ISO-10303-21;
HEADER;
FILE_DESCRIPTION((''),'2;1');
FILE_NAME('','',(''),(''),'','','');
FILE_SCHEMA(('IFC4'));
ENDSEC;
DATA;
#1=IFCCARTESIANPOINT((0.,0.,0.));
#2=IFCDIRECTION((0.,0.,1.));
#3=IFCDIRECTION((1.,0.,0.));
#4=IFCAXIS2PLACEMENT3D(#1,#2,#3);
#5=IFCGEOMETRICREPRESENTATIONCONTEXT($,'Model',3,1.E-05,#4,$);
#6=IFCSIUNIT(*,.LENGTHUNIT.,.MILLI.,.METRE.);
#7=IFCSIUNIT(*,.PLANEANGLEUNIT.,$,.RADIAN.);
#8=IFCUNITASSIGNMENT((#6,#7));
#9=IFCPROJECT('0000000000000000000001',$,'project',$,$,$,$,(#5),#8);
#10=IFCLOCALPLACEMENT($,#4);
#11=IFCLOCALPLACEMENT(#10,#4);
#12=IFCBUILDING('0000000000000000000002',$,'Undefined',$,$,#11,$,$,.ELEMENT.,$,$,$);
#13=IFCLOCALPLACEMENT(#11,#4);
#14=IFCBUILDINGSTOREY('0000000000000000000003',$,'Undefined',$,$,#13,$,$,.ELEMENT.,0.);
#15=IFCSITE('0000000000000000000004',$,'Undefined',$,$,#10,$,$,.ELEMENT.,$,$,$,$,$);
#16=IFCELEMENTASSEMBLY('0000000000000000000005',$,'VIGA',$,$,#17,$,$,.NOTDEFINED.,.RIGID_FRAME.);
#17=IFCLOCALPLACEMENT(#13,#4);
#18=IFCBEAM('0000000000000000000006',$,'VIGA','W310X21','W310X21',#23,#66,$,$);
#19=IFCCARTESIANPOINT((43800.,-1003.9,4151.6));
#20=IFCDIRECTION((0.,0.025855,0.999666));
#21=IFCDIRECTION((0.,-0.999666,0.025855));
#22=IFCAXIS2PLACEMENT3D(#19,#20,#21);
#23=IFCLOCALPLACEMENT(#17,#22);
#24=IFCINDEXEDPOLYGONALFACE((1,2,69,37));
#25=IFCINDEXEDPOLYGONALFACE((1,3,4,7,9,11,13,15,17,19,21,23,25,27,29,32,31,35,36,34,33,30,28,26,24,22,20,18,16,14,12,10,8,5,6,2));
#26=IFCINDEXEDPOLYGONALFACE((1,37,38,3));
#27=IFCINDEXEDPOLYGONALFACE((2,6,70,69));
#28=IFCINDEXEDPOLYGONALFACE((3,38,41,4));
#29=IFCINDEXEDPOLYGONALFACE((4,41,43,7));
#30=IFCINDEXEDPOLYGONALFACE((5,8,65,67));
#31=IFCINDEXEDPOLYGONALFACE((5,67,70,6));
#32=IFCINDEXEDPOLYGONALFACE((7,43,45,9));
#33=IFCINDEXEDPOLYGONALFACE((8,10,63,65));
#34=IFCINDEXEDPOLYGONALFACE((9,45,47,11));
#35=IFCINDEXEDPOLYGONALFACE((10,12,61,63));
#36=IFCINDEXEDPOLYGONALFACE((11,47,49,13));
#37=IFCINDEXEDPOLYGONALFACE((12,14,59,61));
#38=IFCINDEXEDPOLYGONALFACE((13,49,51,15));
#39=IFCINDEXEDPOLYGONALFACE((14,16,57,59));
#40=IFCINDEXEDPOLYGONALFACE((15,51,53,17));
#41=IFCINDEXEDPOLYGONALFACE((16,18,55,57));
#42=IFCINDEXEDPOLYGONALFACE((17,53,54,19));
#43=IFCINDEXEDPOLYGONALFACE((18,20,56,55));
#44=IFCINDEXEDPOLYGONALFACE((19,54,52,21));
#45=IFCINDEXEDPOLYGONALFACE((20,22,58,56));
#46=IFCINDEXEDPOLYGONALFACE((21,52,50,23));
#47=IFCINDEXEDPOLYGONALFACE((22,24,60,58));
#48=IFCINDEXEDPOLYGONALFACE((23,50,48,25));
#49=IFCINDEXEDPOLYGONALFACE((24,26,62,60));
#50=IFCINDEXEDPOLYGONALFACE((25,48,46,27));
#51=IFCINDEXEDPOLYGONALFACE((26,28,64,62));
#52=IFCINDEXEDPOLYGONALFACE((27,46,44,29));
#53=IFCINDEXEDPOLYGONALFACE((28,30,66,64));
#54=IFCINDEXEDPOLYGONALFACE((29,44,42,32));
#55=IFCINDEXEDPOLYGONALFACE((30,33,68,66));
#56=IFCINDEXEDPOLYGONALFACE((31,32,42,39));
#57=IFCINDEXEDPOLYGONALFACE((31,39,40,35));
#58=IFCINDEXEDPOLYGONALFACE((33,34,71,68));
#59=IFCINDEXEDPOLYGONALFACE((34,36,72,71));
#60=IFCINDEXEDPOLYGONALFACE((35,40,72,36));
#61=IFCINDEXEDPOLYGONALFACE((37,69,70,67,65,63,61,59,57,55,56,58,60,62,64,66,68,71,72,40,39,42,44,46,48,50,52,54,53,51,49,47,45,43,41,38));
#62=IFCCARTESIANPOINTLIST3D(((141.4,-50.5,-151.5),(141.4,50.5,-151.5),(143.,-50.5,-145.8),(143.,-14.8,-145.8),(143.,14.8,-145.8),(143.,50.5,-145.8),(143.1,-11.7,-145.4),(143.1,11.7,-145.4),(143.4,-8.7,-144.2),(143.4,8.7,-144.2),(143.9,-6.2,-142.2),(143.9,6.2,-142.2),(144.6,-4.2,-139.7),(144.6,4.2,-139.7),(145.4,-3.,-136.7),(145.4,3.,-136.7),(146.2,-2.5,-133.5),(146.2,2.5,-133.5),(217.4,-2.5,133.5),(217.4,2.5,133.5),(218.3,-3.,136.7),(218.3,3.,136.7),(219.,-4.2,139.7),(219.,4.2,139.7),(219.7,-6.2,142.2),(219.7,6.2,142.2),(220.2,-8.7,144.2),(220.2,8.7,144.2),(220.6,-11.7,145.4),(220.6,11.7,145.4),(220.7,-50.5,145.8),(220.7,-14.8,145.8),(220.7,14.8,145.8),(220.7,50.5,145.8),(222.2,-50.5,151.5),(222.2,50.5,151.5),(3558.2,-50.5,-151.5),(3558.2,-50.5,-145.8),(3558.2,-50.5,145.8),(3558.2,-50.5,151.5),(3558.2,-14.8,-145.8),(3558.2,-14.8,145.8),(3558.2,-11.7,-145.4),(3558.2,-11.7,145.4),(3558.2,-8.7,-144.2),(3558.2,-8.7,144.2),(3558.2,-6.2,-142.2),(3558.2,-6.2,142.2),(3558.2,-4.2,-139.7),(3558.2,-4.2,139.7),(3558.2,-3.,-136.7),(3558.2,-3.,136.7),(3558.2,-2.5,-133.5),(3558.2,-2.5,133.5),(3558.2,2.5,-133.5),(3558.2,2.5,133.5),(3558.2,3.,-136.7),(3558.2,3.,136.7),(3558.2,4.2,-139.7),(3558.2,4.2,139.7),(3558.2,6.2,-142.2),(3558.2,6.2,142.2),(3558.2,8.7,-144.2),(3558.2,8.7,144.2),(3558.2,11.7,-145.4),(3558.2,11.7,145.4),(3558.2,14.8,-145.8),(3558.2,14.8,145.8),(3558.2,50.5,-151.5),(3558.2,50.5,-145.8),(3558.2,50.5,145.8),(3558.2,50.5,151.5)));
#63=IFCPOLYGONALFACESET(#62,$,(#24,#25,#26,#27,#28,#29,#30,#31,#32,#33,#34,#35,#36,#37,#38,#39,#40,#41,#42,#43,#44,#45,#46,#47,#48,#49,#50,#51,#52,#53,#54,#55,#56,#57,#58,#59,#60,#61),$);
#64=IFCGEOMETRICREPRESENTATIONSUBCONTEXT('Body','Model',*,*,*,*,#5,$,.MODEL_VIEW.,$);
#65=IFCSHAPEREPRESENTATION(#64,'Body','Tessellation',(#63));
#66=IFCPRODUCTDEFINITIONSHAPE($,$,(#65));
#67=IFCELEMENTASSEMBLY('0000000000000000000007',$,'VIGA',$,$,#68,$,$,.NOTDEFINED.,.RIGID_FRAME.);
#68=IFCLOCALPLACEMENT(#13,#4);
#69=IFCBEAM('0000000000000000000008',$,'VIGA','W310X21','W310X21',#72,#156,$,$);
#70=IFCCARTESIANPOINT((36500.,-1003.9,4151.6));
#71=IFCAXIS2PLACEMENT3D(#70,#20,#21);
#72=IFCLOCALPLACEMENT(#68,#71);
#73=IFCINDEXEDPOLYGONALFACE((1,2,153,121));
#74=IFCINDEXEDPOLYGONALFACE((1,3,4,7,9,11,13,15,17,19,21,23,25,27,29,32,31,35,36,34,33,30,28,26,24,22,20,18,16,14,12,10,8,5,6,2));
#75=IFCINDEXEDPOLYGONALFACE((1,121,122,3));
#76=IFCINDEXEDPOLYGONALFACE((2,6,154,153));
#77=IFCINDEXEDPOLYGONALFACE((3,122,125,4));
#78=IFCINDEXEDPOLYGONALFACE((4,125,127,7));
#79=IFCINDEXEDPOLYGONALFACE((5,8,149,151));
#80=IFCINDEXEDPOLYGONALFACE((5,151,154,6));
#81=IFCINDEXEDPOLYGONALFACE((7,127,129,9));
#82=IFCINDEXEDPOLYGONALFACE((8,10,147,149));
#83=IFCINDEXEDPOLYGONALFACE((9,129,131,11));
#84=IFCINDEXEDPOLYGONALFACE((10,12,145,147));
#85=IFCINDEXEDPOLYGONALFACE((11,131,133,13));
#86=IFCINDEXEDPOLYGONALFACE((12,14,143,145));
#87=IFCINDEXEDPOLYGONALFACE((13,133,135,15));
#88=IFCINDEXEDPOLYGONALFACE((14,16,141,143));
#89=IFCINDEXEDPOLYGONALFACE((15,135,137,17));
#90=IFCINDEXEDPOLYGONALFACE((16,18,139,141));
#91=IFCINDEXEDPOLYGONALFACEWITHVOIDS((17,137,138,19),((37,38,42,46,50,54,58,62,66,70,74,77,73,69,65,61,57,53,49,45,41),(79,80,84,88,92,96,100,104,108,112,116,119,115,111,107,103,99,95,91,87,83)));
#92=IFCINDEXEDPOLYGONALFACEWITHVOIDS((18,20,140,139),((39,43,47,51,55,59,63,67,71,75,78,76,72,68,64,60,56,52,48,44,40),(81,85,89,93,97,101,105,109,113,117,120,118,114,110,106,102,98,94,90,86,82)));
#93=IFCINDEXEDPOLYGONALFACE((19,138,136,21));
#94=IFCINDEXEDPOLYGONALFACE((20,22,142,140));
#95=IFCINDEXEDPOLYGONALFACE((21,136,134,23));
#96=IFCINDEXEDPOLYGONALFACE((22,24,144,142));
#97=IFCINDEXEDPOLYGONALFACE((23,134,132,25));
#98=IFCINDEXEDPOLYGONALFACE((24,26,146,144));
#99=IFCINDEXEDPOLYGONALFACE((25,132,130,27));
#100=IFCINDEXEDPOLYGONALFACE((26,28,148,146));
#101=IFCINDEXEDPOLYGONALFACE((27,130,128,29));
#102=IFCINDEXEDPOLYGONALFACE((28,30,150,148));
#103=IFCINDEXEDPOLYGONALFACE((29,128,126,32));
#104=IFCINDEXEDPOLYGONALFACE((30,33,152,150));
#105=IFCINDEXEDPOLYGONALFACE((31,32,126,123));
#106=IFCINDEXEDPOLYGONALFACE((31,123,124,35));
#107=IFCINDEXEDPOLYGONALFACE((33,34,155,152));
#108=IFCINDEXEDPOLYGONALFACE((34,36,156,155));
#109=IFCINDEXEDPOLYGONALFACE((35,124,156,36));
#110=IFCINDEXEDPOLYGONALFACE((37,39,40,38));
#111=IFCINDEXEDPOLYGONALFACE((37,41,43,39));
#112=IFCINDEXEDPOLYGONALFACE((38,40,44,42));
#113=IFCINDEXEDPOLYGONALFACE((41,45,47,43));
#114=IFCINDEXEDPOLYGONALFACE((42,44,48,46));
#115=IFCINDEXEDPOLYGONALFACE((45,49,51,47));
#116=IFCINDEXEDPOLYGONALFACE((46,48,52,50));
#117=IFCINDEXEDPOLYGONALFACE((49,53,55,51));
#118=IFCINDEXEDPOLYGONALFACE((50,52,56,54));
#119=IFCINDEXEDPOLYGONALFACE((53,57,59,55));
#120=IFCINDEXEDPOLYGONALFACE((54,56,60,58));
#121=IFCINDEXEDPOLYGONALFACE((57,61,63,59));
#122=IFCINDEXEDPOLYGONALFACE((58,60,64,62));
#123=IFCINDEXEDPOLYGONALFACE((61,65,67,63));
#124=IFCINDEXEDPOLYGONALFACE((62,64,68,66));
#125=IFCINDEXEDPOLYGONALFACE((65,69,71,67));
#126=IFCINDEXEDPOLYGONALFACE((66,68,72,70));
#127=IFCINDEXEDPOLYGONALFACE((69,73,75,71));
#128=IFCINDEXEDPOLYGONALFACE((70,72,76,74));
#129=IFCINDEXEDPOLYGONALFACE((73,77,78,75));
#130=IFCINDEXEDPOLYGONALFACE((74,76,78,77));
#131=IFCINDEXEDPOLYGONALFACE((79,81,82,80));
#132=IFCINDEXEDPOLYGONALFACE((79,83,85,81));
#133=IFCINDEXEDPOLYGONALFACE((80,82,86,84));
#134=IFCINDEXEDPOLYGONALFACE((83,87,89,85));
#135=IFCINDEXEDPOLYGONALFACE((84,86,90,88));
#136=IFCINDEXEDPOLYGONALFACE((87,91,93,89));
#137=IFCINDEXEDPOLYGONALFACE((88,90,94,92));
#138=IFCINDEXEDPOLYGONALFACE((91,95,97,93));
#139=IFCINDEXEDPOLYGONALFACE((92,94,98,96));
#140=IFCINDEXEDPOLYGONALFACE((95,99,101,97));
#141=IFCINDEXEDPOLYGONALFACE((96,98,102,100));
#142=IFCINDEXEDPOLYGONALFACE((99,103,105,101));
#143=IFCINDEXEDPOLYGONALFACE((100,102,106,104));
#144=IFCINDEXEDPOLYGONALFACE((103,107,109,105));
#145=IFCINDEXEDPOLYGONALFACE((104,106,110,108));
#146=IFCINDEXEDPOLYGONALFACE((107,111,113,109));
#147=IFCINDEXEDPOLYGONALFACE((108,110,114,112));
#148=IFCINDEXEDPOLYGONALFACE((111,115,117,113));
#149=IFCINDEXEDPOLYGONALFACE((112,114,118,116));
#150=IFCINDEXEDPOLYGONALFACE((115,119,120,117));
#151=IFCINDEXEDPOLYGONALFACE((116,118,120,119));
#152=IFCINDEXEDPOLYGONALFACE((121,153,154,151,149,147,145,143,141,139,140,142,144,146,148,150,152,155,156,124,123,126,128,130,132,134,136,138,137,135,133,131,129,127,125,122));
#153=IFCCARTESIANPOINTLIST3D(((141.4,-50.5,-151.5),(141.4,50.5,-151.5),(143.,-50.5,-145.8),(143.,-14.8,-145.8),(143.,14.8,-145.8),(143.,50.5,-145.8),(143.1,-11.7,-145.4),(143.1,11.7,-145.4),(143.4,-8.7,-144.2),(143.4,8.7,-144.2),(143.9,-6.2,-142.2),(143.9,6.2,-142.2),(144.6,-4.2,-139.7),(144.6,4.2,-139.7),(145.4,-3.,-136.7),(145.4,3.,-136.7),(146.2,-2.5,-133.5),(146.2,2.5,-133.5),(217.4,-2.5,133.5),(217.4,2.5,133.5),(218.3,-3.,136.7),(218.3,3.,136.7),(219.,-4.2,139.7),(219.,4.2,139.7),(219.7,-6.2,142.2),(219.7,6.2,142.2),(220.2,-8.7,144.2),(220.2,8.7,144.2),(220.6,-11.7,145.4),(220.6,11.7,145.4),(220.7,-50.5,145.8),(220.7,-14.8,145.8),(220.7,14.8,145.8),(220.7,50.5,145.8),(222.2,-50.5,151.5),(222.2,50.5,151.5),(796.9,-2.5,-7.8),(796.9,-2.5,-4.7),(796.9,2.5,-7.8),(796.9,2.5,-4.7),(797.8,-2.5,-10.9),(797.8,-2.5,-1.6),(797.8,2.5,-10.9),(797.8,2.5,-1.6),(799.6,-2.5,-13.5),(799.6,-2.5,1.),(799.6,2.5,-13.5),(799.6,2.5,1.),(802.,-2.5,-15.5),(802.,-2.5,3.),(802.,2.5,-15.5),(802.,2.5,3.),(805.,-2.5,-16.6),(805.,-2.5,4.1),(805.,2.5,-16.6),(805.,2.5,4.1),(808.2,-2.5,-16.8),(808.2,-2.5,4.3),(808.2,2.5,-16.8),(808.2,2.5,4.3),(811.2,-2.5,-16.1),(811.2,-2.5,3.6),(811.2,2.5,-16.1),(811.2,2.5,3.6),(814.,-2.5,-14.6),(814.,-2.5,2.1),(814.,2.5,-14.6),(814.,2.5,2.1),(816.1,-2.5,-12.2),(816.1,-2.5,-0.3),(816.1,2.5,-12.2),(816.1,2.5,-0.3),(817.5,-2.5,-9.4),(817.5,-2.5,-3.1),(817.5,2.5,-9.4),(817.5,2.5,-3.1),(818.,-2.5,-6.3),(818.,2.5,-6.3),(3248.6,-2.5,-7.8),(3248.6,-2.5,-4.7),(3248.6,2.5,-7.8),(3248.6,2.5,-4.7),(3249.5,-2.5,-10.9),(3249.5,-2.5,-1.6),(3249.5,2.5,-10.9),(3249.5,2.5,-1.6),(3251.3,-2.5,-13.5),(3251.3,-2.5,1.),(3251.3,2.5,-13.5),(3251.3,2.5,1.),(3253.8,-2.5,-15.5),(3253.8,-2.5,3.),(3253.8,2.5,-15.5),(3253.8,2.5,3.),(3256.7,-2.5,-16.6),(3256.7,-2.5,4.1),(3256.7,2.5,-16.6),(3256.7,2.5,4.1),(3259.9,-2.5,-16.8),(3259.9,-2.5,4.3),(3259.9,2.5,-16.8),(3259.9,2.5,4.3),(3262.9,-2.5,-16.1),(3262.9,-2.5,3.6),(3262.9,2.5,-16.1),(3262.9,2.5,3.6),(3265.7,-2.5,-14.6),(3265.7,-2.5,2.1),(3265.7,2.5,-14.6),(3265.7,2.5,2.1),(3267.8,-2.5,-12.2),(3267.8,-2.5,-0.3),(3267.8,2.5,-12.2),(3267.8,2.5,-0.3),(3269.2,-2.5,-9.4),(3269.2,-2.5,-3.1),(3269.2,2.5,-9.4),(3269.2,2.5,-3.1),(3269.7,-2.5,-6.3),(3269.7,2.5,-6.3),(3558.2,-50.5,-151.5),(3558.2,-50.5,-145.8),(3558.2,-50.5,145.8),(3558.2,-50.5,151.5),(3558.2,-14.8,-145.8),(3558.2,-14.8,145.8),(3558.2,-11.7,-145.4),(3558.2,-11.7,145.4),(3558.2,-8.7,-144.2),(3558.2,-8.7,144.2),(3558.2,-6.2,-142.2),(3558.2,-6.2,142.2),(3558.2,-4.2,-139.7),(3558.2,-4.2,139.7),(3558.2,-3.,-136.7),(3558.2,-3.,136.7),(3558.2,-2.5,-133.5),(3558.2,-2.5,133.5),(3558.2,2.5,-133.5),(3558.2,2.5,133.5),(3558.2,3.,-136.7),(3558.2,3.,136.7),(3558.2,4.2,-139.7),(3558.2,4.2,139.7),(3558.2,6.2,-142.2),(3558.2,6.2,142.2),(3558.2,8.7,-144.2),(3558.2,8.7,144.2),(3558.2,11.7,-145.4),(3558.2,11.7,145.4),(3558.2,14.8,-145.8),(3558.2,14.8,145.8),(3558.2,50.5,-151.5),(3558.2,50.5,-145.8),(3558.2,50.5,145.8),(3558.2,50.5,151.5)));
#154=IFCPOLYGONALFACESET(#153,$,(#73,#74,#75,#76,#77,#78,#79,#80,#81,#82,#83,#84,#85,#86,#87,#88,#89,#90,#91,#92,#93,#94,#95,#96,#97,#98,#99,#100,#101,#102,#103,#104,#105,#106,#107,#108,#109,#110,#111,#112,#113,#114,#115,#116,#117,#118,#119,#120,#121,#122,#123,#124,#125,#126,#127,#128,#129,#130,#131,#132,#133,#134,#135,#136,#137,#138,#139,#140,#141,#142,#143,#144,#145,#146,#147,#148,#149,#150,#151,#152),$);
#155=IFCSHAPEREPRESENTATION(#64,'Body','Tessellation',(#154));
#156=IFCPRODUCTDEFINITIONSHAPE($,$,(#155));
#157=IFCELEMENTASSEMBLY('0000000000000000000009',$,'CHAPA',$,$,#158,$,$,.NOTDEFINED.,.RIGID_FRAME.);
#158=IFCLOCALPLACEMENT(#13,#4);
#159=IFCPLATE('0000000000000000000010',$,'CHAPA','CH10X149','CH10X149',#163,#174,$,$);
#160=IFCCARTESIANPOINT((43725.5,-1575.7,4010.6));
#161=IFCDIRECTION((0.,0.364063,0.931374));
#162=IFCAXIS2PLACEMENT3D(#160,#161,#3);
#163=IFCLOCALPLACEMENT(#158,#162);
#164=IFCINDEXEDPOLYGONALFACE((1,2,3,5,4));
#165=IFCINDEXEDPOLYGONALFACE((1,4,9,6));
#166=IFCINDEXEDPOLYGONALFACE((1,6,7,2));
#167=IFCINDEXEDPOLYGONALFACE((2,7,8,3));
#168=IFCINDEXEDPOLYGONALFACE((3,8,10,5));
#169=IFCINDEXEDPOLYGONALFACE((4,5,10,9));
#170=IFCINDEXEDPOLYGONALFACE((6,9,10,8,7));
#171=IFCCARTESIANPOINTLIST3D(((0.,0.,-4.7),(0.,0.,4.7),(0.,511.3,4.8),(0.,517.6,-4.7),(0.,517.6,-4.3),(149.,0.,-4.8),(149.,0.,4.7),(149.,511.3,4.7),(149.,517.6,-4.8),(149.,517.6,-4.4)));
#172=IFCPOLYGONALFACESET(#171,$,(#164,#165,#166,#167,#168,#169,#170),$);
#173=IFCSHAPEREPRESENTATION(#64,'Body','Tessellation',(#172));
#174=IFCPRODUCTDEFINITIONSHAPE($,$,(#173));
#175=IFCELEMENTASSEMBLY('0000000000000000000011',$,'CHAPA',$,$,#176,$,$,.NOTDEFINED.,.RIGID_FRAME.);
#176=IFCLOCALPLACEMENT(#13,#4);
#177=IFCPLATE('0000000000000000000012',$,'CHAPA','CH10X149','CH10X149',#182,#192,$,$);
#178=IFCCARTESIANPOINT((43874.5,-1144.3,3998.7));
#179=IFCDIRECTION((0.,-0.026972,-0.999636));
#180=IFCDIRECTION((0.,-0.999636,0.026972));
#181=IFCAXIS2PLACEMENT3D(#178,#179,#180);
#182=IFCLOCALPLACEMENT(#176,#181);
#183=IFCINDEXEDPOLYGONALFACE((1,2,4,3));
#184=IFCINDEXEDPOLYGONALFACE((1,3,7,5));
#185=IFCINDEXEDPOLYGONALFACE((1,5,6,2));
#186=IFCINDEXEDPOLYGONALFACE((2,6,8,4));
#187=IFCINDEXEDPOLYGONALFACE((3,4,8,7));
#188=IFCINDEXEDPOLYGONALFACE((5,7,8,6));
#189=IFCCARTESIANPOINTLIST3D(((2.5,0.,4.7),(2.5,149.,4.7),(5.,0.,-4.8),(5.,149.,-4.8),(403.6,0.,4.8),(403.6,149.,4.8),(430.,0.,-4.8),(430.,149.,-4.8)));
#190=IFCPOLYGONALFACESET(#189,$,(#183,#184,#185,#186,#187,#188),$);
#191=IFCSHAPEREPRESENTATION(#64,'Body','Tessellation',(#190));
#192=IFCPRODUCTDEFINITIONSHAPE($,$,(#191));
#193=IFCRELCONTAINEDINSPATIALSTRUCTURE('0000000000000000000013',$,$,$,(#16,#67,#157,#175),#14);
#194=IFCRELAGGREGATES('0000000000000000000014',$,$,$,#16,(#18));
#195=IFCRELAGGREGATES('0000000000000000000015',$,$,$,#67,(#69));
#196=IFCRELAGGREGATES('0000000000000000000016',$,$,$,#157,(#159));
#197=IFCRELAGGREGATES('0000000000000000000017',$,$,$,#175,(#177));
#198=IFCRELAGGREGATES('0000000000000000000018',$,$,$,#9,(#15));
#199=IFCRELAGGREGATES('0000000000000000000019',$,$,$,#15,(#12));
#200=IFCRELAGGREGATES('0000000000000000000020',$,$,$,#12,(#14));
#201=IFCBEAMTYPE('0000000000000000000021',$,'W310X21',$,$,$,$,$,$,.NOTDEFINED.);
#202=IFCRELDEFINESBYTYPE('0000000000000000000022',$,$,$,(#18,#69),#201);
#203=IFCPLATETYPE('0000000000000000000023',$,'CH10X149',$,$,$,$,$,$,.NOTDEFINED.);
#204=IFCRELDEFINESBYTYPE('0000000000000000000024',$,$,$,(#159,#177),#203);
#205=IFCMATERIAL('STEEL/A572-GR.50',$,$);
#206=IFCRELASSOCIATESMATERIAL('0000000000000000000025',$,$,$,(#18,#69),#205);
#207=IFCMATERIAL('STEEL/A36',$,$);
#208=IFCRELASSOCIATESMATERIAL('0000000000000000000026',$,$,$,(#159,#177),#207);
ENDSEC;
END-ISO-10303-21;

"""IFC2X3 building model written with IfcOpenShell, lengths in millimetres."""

from ifc_helpers import new_model, si_unit, frame, origin_with_axes, origin_2d_with_axis, place, context, subcontext, project, spatial, polyline, circle, i_section, outline, extrude, boolean, clip, halfspace, material, type_object, element, aggregate, save


model = new_model("IFC2X3")

# Units and contexts
model_context = context("Model", 3, precision=1e-05, world=origin_with_axes())
body_context = subcontext(model_context, "Body", "Model", "MODEL_VIEW")
ifc_project = project(units=[si_unit("LENGTHUNIT", "METRE", prefix="MILLI"), si_unit("PLANEANGLEUNIT", "RADIAN")], contexts=[model_context])

# Site, building, storey
site_placement = place(None, origin_with_axes())
site = spatial("IfcSite", under=ifc_project, at=site_placement, Name="Undefined", CompositionType="ELEMENT")
building_placement = place(site_placement, origin_with_axes())
building = spatial("IfcBuilding", under=site, at=building_placement, Name="Undefined", CompositionType="ELEMENT")
storey_placement = place(building_placement, origin_with_axes())
storey = spatial("IfcBuildingStorey", under=building, at=storey_placement, Name="Undefined", CompositionType="ELEMENT", Elevation=0.0)

# Element assemblies, beams
ifc_material_1 = material(Name="STEEL/A572-GR.50")
assembly_1_placement = place(storey_placement, origin_with_axes())
assembly_1 = element("IfcElementAssembly", 1, at=assembly_1_placement, inside=storey, Name="VIGA", AssemblyPlace="NOTDEFINED", PredefinedType="RIGID_FRAME")
beam_type_1 = type_object("IfcBeamType", Name="W310X21", PredefinedType="NOTDEFINED")
beam_1_placement = place(assembly_1_placement, frame((43800.0, -1003.9, 4151.6), z_axis=(0.0, 0.025855, 0.999666), x_axis=(0.0, -0.999666, 0.025855)))
beam_1 = element("IfcBeam", 2, at=beam_1_placement, type_object=beam_type_1, material=ifc_material_1, Name="VIGA", Description="W310X21", ObjectType="W310X21", context=body_context, shape_type="Clipping", body=[
    clip(extrude(i_section(OverallWidth=101.0, OverallDepth=303.0, WebThickness=5.1, FlangeThickness=5.7, FilletRadius=12.3, at=origin_2d_with_axis()), frame((3558.2, 0.0, 0.0), z_axis=(-1.0, 0.0, 0.0), x_axis=(0.0, -1.0, 0.0)), (0.0, 0.0, 1.0), 3558.2), halfspace(frame((141.4, 50.5, -151.7), z_axis=(-0.966259, 0.0, 0.257573), x_axis=(0.257573, 0.0, 0.966259)), False)),
])
aggregate(assembly_1, [beam_1])
assembly_2_placement = place(storey_placement, origin_with_axes())
assembly_2 = element("IfcElementAssembly", 3, at=assembly_2_placement, inside=storey, Name="VIGA", AssemblyPlace="NOTDEFINED", PredefinedType="RIGID_FRAME")
beam_2_placement = place(assembly_2_placement, frame((36500.0, -1003.9, 4151.6), z_axis=(0.0, 0.025855, 0.999666), x_axis=(0.0, -0.999666, 0.025855)))
beam_2 = element("IfcBeam", 4, at=beam_2_placement, type_object=beam_type_1, material=ifc_material_1, Name="VIGA", Description="W310X21", ObjectType="W310X21", context=body_context, shape_type="CSG", body=[
    boolean("DIFFERENCE", boolean("DIFFERENCE", boolean("DIFFERENCE", extrude(i_section(OverallWidth=101.0, OverallDepth=303.0, WebThickness=5.1, FlangeThickness=5.7, FilletRadius=12.3, at=origin_2d_with_axis()), frame((3558.2, 0.0, 0.0), z_axis=(-1.0, 0.0, 0.0), x_axis=(0.0, -1.0, 0.0)), (0.0, 0.0, 1.0), 3558.2), extrude(circle(Radius=10.6, at=origin_2d_with_axis()), frame((3259.1, 100.0, -6.3), z_axis=(0.0, -1.0, 0.0), x_axis=(1.0, 0.0, 0.0)), (0.0, 0.0, 1.0), 200.0)), extrude(circle(Radius=10.6, at=origin_2d_with_axis()), frame((807.4, 100.0, -6.3), z_axis=(0.0, -1.0, 0.0), x_axis=(1.0, 0.0, 0.0)), (0.0, 0.0, 1.0), 200.0)), halfspace(frame((141.4, 50.5, -151.7), z_axis=(-0.966259, 0.0, 0.257573), x_axis=(0.257573, 0.0, 0.966259)), False)),
])
aggregate(assembly_2, [beam_2])

# Shared definitions
ifc_material_2 = material(Name="STEEL/A36")

# Element assemblies, plates
assembly_3_placement = place(storey_placement, origin_with_axes())
assembly_3 = element("IfcElementAssembly", 5, at=assembly_3_placement, inside=storey, Name="CHAPA", AssemblyPlace="NOTDEFINED", PredefinedType="RIGID_FRAME")
plate_type_1 = type_object("IfcPlateType", Name="CH10X149", PredefinedType="NOTDEFINED")
plate_1_placement = place(assembly_3_placement, frame((43725.5, -1575.7, 4010.6), z_axis=(0.0, 0.364063, 0.931374), x_axis=(1.0, 0.0, 0.0)))
plate_1 = element("IfcPlate", 6, at=plate_1_placement, type_object=plate_type_1, material=ifc_material_2, Name="CHAPA", Description="CH10X149", ObjectType="CH10X149", context=body_context, shape_type="Clipping", body=[
    clip(extrude(outline(polyline([(0.0, 0.0), (149.0, 0.0), (149.0, 517.6), (0.0, 517.6), (0.0, 0.0)])), frame((0.0, 0.0, -4.8), z_axis=(0.0, 0.0, 1.0), x_axis=(1.0, 0.0, 0.0)), (0.0, 0.0, 1.0), 9.5), halfspace(frame((149.0, 517.9, -4.7), z_axis=(0.0, 0.821204, 0.570634), x_axis=(0.0, -0.570634, 0.821204)), False)),
])
aggregate(assembly_3, [plate_1])
assembly_4_placement = place(storey_placement, origin_with_axes())
assembly_4 = element("IfcElementAssembly", 7, at=assembly_4_placement, inside=storey, Name="CHAPA", AssemblyPlace="NOTDEFINED", PredefinedType="RIGID_FRAME")
plate_2_placement = place(assembly_4_placement, frame((43874.5, -1144.3, 3998.7), z_axis=(0.0, -0.026972, -0.999636), x_axis=(0.0, -0.999636, 0.026972)))
plate_2 = element("IfcPlate", 8, at=plate_2_placement, type_object=plate_type_1, material=ifc_material_2, Name="CHAPA", Description="CH10X149", ObjectType="CH10X149", context=body_context, shape_type="Clipping", body=[
    clip(clip(extrude(outline(polyline([(0.0, 0.0), (430.0, 0.0), (430.0, 149.0), (0.0, 149.0), (0.0, 0.0)])), frame((0.0, 0.0, -4.8), z_axis=(0.0, 0.0, 1.0), x_axis=(1.0, 0.0, 0.0)), (0.0, 0.0, 1.0), 9.5), halfspace(frame((403.6, -500.0, 4.7), z_axis=(0.33881, 0.0, 0.940855), x_axis=(0.0, 1.0, 0.0)), False)), halfspace(frame((5.0, -500.0, -4.8), z_axis=(-0.965989, 0.0, -0.258583), x_axis=(0.0, 1.0, 0.0)), False)),
])
aggregate(assembly_4, [plate_2])

save(model, "model.ifc")
